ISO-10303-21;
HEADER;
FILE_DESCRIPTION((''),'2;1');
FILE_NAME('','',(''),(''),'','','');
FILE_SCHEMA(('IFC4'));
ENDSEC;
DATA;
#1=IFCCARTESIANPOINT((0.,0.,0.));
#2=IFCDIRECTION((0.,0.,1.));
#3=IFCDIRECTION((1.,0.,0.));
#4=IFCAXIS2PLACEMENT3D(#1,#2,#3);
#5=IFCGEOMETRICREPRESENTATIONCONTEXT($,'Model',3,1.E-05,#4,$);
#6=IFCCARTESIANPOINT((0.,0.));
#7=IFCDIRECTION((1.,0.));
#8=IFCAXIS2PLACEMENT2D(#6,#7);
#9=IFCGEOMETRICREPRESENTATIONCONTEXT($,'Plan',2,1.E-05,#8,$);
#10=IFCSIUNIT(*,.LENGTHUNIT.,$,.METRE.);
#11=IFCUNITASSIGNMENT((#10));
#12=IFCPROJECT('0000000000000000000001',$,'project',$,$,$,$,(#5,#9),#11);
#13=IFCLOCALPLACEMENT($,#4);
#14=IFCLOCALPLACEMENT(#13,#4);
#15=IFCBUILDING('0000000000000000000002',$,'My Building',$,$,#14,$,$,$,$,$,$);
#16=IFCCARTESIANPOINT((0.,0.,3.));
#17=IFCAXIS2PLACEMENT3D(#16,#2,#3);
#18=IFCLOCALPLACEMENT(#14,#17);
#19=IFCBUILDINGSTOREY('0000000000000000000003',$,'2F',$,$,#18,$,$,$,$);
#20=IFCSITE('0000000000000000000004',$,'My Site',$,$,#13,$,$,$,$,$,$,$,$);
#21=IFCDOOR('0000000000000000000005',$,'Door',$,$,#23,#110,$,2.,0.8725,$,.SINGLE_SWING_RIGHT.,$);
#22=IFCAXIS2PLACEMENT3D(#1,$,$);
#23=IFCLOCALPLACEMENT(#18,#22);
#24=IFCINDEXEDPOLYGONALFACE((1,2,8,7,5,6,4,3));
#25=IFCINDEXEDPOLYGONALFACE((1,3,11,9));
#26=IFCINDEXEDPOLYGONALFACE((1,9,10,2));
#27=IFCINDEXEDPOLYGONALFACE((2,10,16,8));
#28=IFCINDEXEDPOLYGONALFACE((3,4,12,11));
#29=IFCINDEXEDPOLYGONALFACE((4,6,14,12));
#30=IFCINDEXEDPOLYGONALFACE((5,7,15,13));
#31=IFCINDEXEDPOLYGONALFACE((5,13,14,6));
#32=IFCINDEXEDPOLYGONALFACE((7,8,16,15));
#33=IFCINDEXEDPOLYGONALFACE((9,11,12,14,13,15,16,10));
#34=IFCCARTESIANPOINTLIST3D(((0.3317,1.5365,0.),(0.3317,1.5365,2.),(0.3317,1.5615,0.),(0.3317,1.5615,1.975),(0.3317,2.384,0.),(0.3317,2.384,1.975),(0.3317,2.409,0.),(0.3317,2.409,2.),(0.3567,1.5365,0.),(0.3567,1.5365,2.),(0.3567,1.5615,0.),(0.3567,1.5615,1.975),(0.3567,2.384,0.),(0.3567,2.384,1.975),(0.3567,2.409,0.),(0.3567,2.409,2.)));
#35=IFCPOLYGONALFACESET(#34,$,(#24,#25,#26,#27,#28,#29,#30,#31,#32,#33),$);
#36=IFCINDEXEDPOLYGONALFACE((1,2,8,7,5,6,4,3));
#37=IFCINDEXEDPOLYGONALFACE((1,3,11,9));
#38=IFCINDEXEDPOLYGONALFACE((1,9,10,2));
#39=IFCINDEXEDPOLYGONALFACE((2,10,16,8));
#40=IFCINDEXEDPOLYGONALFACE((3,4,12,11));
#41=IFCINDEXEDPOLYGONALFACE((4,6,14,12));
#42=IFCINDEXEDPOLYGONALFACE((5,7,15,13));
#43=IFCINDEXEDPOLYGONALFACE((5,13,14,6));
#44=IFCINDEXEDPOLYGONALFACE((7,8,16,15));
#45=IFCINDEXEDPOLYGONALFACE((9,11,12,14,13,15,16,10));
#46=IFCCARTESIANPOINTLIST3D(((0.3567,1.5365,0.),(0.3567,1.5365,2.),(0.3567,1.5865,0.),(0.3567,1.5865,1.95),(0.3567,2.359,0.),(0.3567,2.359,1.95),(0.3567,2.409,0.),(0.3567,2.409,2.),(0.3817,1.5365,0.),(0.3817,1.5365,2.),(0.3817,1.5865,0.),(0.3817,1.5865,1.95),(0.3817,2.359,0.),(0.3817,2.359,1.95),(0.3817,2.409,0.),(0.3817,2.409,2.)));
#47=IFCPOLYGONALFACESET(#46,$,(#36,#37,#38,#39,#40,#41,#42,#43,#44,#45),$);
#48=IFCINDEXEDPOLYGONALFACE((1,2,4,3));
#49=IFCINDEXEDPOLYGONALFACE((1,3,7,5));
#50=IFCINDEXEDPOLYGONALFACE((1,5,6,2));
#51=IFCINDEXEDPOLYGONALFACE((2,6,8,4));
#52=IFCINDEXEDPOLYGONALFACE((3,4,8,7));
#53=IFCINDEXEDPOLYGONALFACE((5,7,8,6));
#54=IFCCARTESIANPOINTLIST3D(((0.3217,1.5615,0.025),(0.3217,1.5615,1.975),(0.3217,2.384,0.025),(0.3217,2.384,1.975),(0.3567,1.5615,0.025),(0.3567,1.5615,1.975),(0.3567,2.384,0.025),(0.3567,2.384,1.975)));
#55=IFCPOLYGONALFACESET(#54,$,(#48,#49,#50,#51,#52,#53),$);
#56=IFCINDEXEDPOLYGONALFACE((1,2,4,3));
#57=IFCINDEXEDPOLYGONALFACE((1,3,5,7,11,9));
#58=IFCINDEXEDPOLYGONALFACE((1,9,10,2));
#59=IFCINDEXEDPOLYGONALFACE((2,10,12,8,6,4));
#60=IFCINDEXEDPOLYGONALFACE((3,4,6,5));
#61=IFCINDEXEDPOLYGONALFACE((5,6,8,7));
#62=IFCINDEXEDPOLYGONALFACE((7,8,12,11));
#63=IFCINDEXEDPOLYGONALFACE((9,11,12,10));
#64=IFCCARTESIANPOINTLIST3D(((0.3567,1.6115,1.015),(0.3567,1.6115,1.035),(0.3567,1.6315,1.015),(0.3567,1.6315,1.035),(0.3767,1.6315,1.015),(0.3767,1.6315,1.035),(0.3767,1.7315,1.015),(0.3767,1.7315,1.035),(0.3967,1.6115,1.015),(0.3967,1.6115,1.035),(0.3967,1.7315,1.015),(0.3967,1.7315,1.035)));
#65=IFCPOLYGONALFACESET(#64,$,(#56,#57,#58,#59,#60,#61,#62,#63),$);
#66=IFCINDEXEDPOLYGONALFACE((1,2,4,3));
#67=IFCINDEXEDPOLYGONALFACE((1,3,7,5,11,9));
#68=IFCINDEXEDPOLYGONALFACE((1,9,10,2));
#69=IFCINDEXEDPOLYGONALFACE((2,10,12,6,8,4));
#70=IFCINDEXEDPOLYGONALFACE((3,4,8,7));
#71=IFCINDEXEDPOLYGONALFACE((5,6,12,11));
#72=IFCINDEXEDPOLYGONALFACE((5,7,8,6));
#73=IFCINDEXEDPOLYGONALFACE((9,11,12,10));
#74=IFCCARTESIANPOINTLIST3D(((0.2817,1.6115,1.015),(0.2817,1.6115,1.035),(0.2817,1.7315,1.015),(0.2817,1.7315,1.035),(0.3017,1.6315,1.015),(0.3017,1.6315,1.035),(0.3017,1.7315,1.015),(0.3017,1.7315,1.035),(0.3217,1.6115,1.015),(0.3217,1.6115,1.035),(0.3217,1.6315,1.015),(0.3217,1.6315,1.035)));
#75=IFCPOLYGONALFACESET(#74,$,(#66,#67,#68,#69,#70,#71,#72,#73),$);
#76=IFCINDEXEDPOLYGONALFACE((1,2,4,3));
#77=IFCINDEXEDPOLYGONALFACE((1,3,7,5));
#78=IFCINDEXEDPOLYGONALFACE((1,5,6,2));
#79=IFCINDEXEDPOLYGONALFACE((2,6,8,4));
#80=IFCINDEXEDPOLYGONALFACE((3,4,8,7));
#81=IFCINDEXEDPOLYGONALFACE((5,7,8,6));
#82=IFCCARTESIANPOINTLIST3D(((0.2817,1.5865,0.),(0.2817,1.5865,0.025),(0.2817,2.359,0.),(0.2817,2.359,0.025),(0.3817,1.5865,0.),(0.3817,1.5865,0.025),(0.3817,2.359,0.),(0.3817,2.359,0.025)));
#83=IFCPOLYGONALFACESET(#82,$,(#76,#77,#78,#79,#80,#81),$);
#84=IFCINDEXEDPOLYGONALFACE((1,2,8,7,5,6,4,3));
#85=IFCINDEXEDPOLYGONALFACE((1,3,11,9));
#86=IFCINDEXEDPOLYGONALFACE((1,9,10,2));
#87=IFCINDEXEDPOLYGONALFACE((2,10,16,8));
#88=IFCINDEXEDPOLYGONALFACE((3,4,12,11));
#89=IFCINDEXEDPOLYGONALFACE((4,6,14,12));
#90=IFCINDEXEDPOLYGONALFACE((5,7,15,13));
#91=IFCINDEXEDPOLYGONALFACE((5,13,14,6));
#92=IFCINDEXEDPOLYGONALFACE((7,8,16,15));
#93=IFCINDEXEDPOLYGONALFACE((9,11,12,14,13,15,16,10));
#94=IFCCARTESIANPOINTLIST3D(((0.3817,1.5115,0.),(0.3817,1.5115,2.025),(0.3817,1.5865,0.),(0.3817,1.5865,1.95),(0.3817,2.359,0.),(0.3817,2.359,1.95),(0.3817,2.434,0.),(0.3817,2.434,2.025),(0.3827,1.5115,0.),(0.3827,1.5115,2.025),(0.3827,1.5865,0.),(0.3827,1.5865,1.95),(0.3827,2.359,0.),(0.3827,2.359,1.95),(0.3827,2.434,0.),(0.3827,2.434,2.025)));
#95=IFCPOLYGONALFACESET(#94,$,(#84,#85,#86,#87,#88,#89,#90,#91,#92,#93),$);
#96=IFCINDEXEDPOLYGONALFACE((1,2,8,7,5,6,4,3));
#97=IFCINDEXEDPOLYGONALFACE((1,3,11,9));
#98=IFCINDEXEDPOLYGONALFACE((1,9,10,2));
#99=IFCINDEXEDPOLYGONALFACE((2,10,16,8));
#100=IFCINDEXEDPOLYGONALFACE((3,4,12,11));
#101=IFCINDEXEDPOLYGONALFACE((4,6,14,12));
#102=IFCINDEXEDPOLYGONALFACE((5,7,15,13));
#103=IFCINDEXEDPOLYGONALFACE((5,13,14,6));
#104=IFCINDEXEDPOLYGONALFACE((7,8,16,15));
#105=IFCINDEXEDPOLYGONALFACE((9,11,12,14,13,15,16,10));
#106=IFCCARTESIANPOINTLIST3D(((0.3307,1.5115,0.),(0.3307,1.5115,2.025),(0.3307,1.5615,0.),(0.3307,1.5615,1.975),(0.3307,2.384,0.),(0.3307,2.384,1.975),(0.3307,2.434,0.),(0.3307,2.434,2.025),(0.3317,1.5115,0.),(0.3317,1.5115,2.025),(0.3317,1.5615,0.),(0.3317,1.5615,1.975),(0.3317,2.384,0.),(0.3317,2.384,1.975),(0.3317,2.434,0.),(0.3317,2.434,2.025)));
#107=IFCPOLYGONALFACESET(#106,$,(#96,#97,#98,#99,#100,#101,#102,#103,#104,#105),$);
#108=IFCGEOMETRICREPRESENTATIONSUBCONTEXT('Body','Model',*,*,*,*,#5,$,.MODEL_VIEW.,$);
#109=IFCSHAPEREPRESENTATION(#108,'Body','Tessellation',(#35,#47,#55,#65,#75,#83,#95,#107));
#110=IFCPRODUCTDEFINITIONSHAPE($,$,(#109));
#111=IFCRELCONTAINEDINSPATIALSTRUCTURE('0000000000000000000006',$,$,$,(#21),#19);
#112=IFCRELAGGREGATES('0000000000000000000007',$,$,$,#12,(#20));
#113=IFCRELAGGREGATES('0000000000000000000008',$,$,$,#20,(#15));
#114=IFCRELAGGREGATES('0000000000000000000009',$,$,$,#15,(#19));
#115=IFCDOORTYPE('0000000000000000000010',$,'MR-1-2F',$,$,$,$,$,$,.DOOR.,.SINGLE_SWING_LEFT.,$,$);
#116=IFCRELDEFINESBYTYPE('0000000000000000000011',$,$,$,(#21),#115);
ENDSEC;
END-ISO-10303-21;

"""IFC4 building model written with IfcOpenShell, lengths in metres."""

from ifc_helpers import new_model, entity, si_unit, frame, origin_with_axes, origin_2d_with_axis, place, context, subcontext, project, spatial, line, indexed_curve, outline, extrude, shape, source, transform, mapped, type_object, type_shapes, element, save


model = new_model("IFC4")

# Units and contexts
model_context = context("Model", 3, precision=1e-05, world=origin_with_axes())
plan_context = context("Plan", 2, precision=1e-05, world=origin_2d_with_axis())
body_context_1 = subcontext(model_context, "Body", "Model", "MODEL_VIEW")
body_context_2 = subcontext(plan_context, "Body", "Plan", "PLAN_VIEW")
ifc_project = project(units=[si_unit("LENGTHUNIT", "METRE")], contexts=[model_context, plan_context])

# Site, building, storey
site_placement = place(None, origin_with_axes())
site = spatial("IfcSite", under=ifc_project, at=site_placement, Name="My Site")
building_placement = place(site_placement, origin_with_axes())
building = spatial("IfcBuilding", under=site, at=building_placement, Name="My Building")
storey_placement = place(building_placement, frame((0.0, 0.0, 3.0), z_axis=(0.0, 0.0, 1.0), x_axis=(1.0, 0.0, 0.0)))
storey = spatial("IfcBuildingStorey", under=building, at=storey_placement, Name="2F")

# Door
placement_1 = place(storey_placement, frame((0.2817, 6.52, 0.0), z_axis=(0.0, 0.0, 1.0), x_axis=(0.0, -1.0, 0.0)))
door_type_1 = type_object("IfcDoorType", Name="MR-1-2F", OperationType="SINGLE_SWING_LEFT", PredefinedType="DOOR")
shared_shape_1 = source(origin_with_axes(), body_context_1, "Body", "SweptSolid", [
    extrude(outline(indexed_curve([(0.0, 0.0), (0.0, 2.0), (0.8725, 2.0), (0.8725, 0.0), (0.8475, 0.0), (0.8475, 1.975), (0.025, 1.975), (0.025, 0.0)], segments=[line(1, 2, 3, 4, 5, 6, 7, 8, 1)])), frame((0.0, 0.025, 0.0), z_axis=(0.0, -1.0, 0.0), x_axis=(1.0, 0.0, 0.0)), (0.0, 0.0, -1.0), 0.025),
    extrude(outline(indexed_curve([(0.0, 0.0), (0.0, 2.0), (0.8725, 2.0), (0.8725, 0.0), (0.8225, 0.0), (0.8225, 1.95), (0.05, 1.95), (0.05, 0.0)], segments=[line(1, 2, 3, 4, 5, 6, 7, 8, 1)])), frame((0.0, 0.0, 0.0), z_axis=(0.0, -1.0, 0.0), x_axis=(1.0, 0.0, 0.0)), (0.0, 0.0, -1.0), 0.025),
    extrude(outline(indexed_curve([(0.0, 0.0), (0.8225, 0.0), (0.8225, 0.035), (0.0, 0.035)], segments=[line(1, 2, 3, 4, 1)])), frame((0.025, 0.025, 0.025), z_axis=(0.0, 0.0, 1.0), x_axis=(1.0, 0.0, 0.0)), (0.0, 0.0, 1.0), 1.95),
    extrude(outline(indexed_curve([(0.0, 0.0), (0.0, -0.04), (0.12, -0.04), (0.12, -0.02), (0.02, -0.02), (0.02, 0.0)], segments=[line(1, 2, 3, 4, 5, 6, 1)])), frame((0.075, 0.025, 1.015), z_axis=(0.0, 0.0, 1.0), x_axis=(1.0, 0.0, 0.0)), (0.0, 0.0, 1.0), 0.02),
    extrude(outline(indexed_curve([(0.0, 0.0), (0.0, 0.04), (0.12, 0.04), (0.12, 0.02), (0.02, 0.02), (0.02, 0.0)], segments=[line(1, 2, 3, 4, 5, 6, 1)])), frame((0.075, 0.06, 1.015), z_axis=(0.0, 0.0, 1.0), x_axis=(1.0, 0.0, 0.0)), (0.0, 0.0, 1.0), 0.02),
    extrude(outline(indexed_curve([(0.0, 0.0), (0.7725, 0.0), (0.7725, 0.1), (0.0, 0.1)], segments=[line(1, 2, 3, 4, 1)])), frame((0.05, 0.0, 0.0), z_axis=(0.0, 0.0, 1.0), x_axis=(1.0, 0.0, 0.0)), (0.0, 0.0, 1.0), 0.025),
    extrude(outline(indexed_curve([(0.0, 0.0), (0.0, 2.025), (0.9225, 2.025), (0.9225, 0.0), (0.8475, 0.0), (0.8475, 1.95), (0.075, 1.95), (0.075, 0.0)], segments=[line(1, 2, 3, 4, 5, 6, 7, 8, 1)])), frame((-0.025, -0.001, 0.0), z_axis=(0.0, -1.0, 0.0), x_axis=(1.0, 0.0, 0.0)), (0.0, 0.0, -1.0), 0.001),
    extrude(outline(indexed_curve([(0.0, 0.0), (0.0, 2.025), (0.9225, 2.025), (0.9225, 0.0), (0.8725, 0.0), (0.8725, 1.975), (0.05, 1.975), (0.05, 0.0)], segments=[line(1, 2, 3, 4, 5, 6, 7, 8, 1)])), frame((-0.025, 0.05, 0.0), z_axis=(0.0, -1.0, 0.0), x_axis=(1.0, 0.0, 0.0)), (0.0, 0.0, -1.0), 0.001),
])
shared_shape_2 = source(origin_with_axes(), body_context_2, "Body", "Curve2D", [
    entity("IfcIndexedPolyCurve", entity("IfcCartesianPointList2D", [[0.0, 0.0], [0.0, 0.05], [0.025, 0.05], [0.025, 0.025], [0.05, 0.025], [0.05, 0.0]]), [entity("IfcLineIndex", [1, 2, 3, 4, 5, 6, 1])]),
    entity("IfcIndexedPolyCurve", entity("IfcCartesianPointList2D", [[0.8725, 0.0], [0.8725, 0.05], [0.8475, 0.05], [0.8475, 0.025], [0.8225, 0.025], [0.8225, 0.0]]), [entity("IfcLineIndex", [1, 2, 3, 4, 5, 6, 1])]),
    entity("IfcTrimmedCurve", entity("IfcEllipse", entity("IfcAxis2Placement2D", entity("IfcCartesianPoint", [0.8125, 0.05]), entity("IfcDirection", [1.0, 0.0])), 0.7875, 0.8225), [entity("IfcCartesianPoint", [0.8125, 0.8725])], [entity("IfcCartesianPoint", [0.025, 0.05])], True, "CARTESIAN"),
    entity("IfcIndexedPolyCurve", entity("IfcCartesianPointList2D", [[0.8475, 0.05], [0.8125, 0.05], [0.8125, 0.8725], [0.8475, 0.8725]]), [entity("IfcLineIndex", [1, 2, 3, 4, 1])]),
])
type_shapes(door_type_1, [shared_shape_1, shared_shape_2])
placement_2 = place(placement_1, frame((4.9835, 0.1, 0.0), z_axis=(0.0, 0.0, 1.0), x_axis=(-1.0, 0.0, 0.0)))
door_1_placement = place(placement_2, frame((0.0, 0.0, 0.0), z_axis=(0.0, 0.0, 1.0), x_axis=(1.0, 0.0, 0.0)))
element("IfcDoor", 1, at=door_1_placement, inside=storey, type_object=door_type_1, Name="Door", OperationType="SINGLE_SWING_RIGHT", OverallHeight=2.0, OverallWidth=0.8725, shapes=[
    shape(body_context_1, "Body", "MappedRepresentation", [mapped(shared_shape_1, transform((0.0, 0.0, 0.0), x_axis=(1.0, 0.0, 0.0), y_axis=(0.0, 1.0, 0.0), z_axis=(0.0, 0.0, 1.0), scale=1.0))]),
    shape(body_context_2, "Body", "MappedRepresentation", [mapped(shared_shape_2, transform((0.0, 0.0, 0.0), x_axis=(1.0, 0.0, 0.0), y_axis=(0.0, 1.0, 0.0), z_axis=(0.0, 0.0, 1.0), scale=1.0))]),
])

save(model, "model.ifc")
